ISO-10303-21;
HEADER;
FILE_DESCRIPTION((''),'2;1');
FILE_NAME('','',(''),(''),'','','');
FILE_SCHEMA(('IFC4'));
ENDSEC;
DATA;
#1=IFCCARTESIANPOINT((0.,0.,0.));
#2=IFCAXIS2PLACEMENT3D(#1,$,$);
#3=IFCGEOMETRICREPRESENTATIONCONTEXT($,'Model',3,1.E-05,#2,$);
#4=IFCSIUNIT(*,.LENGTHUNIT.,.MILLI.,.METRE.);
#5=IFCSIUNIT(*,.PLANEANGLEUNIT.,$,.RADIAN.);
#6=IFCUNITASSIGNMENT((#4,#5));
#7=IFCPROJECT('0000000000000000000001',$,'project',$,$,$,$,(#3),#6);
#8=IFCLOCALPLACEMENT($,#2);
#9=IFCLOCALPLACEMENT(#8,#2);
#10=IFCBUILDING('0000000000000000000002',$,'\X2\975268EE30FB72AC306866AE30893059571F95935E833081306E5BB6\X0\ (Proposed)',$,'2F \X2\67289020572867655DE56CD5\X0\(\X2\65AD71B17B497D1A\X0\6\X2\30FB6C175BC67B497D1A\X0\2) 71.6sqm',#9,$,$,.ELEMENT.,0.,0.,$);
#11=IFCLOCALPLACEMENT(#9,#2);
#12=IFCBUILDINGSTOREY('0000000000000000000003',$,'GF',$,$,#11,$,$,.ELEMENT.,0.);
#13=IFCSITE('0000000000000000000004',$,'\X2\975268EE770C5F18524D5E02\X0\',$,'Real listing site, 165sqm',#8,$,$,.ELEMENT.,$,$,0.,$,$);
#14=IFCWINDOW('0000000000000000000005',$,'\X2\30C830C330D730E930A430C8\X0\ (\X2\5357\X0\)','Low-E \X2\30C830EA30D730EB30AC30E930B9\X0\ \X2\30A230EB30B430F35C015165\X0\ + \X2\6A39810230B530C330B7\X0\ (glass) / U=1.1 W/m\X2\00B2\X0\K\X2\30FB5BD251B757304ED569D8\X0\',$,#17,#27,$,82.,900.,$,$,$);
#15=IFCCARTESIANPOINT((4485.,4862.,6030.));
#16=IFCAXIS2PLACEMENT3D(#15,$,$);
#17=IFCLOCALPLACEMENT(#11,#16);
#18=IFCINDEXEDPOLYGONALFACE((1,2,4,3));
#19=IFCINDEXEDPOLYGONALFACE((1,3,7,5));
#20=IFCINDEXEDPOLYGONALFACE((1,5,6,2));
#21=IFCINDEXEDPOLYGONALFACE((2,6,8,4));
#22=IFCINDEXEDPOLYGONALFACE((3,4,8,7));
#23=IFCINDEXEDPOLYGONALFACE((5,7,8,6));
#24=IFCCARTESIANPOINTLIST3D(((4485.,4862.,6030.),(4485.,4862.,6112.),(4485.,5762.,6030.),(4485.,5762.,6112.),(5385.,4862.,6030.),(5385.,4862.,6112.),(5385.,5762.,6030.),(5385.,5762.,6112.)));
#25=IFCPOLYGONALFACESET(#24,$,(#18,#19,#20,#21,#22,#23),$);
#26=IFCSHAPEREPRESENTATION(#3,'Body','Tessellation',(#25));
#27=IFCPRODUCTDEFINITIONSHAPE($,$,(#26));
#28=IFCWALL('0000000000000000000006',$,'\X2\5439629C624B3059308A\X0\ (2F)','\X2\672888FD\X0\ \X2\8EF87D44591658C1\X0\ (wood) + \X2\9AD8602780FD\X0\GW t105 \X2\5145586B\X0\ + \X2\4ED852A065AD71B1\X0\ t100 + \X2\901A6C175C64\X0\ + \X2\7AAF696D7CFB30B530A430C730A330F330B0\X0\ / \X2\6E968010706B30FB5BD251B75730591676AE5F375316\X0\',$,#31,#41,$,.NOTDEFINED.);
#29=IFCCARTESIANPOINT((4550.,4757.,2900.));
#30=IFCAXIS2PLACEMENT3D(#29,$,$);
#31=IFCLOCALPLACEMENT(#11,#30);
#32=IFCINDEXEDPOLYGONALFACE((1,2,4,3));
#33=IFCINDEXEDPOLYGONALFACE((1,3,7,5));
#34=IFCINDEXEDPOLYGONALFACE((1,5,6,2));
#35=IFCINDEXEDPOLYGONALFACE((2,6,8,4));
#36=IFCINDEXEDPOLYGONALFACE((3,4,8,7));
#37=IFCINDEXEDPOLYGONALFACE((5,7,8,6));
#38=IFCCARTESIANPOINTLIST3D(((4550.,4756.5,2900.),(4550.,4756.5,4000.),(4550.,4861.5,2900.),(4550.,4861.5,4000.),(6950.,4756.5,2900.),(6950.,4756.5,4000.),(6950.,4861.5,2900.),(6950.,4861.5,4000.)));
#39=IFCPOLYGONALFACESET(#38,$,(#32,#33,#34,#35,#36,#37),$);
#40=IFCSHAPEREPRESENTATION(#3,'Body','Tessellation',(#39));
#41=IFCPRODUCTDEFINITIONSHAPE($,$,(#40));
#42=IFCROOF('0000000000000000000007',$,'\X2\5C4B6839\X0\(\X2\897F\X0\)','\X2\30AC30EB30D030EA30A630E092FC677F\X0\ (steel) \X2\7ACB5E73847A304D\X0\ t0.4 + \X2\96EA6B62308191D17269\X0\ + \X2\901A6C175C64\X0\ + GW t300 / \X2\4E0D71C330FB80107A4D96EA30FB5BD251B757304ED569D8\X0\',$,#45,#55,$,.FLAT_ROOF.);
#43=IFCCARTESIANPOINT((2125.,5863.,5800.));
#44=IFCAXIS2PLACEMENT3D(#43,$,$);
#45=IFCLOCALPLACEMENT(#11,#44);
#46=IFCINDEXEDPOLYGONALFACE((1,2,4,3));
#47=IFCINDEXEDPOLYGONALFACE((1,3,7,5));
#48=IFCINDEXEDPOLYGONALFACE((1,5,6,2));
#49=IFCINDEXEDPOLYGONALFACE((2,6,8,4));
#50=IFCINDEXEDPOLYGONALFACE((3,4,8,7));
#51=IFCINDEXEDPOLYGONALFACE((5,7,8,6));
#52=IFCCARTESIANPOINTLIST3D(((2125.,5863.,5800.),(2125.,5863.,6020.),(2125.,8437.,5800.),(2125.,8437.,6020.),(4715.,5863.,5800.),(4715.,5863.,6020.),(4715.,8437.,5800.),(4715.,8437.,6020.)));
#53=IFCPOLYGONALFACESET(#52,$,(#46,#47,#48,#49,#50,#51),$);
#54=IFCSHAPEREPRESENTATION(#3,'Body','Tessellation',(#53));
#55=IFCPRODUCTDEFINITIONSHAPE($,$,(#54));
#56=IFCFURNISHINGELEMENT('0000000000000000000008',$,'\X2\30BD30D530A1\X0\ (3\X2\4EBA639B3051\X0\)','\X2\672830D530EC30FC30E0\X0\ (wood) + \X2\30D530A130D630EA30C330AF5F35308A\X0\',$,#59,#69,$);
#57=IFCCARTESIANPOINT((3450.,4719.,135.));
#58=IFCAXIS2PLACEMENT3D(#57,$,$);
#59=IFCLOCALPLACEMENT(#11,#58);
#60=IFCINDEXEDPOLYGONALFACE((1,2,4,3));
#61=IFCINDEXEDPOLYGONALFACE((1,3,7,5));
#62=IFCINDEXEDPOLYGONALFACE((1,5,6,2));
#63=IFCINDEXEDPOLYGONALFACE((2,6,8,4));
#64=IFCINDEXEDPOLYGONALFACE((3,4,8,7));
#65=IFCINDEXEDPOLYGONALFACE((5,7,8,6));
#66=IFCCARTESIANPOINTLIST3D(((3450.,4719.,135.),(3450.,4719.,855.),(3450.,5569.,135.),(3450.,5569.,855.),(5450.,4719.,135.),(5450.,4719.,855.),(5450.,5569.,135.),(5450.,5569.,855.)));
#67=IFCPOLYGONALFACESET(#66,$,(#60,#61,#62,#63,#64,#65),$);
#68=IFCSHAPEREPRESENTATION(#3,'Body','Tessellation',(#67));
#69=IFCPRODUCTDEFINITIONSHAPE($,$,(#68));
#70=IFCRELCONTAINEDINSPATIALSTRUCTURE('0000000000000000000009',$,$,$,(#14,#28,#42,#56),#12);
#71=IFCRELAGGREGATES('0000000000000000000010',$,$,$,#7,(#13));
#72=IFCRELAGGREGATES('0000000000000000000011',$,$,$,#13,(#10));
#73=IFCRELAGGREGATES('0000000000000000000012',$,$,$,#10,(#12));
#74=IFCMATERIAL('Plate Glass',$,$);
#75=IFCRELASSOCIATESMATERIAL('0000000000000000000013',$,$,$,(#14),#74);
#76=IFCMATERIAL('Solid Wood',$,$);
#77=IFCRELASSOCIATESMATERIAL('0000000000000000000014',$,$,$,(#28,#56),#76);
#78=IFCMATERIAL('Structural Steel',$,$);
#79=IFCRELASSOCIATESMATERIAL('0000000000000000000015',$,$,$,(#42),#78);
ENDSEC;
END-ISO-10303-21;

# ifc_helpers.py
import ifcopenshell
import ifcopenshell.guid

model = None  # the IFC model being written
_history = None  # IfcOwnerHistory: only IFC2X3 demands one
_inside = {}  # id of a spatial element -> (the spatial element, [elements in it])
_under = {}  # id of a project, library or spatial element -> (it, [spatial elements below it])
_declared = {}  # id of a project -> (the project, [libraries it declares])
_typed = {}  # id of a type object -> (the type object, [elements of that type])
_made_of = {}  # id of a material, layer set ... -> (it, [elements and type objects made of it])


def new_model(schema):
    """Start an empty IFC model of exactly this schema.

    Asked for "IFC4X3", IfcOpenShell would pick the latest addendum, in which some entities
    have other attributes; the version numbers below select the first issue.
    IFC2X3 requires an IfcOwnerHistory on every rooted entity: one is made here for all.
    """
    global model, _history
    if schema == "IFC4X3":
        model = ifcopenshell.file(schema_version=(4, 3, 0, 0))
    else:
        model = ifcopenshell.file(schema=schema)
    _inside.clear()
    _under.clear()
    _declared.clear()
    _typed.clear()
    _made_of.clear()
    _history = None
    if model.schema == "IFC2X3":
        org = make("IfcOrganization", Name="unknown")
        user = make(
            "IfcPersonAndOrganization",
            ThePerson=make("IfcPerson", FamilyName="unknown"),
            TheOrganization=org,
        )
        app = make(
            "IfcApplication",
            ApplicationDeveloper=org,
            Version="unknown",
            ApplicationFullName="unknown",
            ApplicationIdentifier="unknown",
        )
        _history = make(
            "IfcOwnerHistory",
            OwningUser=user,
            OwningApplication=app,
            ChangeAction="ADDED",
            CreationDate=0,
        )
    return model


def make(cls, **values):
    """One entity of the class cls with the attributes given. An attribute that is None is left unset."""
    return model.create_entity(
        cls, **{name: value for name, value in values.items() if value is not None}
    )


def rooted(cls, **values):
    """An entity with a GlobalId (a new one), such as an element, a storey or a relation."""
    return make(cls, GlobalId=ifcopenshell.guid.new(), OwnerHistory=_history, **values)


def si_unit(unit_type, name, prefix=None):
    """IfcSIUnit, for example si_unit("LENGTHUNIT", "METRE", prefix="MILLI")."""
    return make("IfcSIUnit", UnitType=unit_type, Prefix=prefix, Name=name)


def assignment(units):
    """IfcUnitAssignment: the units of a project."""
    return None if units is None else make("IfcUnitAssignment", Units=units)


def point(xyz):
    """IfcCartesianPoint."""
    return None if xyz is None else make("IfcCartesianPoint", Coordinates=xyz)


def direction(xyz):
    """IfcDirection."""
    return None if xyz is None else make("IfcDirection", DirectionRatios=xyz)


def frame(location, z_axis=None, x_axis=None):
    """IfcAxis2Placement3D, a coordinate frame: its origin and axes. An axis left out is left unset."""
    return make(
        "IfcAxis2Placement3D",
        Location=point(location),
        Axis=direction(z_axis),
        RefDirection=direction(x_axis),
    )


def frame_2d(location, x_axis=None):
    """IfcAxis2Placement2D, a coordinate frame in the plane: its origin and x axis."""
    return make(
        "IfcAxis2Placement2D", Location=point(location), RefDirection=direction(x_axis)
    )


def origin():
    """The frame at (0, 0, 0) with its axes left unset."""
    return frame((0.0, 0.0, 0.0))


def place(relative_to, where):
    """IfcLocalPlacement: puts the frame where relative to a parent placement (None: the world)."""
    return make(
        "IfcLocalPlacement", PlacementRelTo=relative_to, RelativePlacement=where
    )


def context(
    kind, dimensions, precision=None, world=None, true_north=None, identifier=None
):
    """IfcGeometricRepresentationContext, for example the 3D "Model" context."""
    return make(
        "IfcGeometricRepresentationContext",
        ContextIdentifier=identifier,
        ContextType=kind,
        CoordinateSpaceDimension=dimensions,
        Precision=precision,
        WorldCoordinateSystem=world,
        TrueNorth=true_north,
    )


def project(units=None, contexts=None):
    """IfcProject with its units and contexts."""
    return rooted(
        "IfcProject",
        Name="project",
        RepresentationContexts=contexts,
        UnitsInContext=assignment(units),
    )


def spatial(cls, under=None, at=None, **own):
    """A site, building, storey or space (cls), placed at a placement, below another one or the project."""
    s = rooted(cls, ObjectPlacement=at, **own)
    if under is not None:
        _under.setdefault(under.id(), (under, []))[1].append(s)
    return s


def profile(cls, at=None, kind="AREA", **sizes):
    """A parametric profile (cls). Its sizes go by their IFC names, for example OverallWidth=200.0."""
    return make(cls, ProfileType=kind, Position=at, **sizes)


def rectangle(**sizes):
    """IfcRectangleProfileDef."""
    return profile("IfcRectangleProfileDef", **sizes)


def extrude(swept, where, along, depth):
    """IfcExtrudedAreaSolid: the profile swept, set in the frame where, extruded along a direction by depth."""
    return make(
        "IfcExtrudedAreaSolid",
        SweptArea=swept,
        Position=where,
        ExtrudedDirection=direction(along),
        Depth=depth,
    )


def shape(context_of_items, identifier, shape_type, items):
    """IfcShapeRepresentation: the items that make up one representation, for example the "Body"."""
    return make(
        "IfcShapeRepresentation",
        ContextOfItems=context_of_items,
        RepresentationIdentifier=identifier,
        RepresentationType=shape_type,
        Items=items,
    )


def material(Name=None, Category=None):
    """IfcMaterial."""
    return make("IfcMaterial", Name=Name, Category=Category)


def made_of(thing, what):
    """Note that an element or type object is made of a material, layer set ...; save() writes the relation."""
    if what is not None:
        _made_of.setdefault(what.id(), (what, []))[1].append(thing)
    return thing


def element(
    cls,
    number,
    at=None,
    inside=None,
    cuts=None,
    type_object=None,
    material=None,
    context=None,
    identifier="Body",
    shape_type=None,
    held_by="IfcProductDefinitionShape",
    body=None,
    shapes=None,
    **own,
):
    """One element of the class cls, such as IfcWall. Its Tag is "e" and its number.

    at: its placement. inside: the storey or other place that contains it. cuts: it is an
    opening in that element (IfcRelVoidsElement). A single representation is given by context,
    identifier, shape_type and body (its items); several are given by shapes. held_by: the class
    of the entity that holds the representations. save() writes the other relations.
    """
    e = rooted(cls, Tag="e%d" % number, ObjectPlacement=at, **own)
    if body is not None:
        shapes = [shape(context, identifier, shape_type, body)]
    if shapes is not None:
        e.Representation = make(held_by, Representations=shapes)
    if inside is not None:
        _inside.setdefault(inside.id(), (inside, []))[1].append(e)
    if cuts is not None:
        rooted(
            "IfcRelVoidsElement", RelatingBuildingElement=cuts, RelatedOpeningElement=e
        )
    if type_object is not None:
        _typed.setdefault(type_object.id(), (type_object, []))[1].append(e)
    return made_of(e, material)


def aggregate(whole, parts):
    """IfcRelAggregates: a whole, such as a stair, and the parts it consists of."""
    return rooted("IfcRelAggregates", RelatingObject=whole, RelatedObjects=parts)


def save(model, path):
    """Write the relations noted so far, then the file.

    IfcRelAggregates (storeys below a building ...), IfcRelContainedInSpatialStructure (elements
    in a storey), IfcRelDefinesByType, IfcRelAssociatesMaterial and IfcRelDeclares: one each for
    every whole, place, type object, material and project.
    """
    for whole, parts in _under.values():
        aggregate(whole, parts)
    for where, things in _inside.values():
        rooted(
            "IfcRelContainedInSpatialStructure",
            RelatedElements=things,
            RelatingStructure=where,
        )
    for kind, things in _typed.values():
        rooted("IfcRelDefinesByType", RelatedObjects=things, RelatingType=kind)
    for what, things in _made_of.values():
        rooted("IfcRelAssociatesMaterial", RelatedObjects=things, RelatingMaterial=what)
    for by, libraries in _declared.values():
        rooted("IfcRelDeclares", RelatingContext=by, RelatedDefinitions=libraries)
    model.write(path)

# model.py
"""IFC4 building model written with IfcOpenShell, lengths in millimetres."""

from ifc_helpers import new_model, si_unit, frame, frame_2d, origin, place, context, project, spatial, rectangle, extrude, material, element, save


model = new_model("IFC4")

# Units and contexts
model_context = context("Model", 3, precision=1e-05, world=origin())
ifc_project = project(units=[si_unit("LENGTHUNIT", "METRE", prefix="MILLI"), si_unit("PLANEANGLEUNIT", "RADIAN")], contexts=[model_context])

# Site, building, storey
site_placement = place(None, origin())
site = spatial("IfcSite", under=ifc_project, at=site_placement, Name="青森県弘前市", ObjectType="Real listing site, 165sqm", CompositionType="ELEMENT", RefElevation=0.0)
building_placement = place(site_placement, origin())
building = spatial("IfcBuilding", under=site, at=building_placement, Name="青森・犬と暮らす土間広めの家 (Proposed)", ObjectType="2F 木造在来工法(断熱等級6・気密等級2) 71.6sqm", CompositionType="ELEMENT", ElevationOfRefHeight=0.0, ElevationOfTerrain=0.0)
storey_placement = place(building_placement, origin())
storey = spatial("IfcBuildingStorey", under=building, at=storey_placement, Name="GF", CompositionType="ELEMENT", Elevation=0.0)

# Shared definitions
ifc_material_1 = material(Name="Solid Wood")

# Shared definitions
ifc_material_2 = material(Name="Plate Glass")

# Window
window_1_placement = place(storey_placement, frame((4485.0, 4862.0, 6030.0)))
element("IfcWindow", 1, at=window_1_placement, inside=storey, material=ifc_material_2, Name="トップライト (南)", Description="Low-E トリプルガラス アルゴン封入 + 樹脂サッシ (glass) / U=1.1 W/m²K・寒冷地仕様", OverallHeight=82.0, OverallWidth=900.0, context=model_context, shape_type="SweptSolid", body=[
    extrude(rectangle(XDim=900.0, YDim=900.0, at=frame_2d((450.0, 450.0))), frame((4485.0, 4862.0, 6030.0)), (0.0, 0.0, 1.0), 82.0),
])

# Wall
wall_1_placement = place(storey_placement, frame((4550.0, 4757.0, 2900.0)))
element("IfcWall", 2, at=wall_1_placement, inside=storey, material=ifc_material_1, Name="吹抜手すり (2F)", Description="木製 軸組外壁 (wood) + 高性能GW t105 充填 + 付加断熱 t100 + 通気層 + 窯業系サイディング / 準耐火・寒冷地外皮強化", PredefinedType="NOTDEFINED", context=model_context, shape_type="SweptSolid", body=[
    extrude(rectangle(XDim=2400.0, YDim=105.0, at=frame_2d((1200.0, 52.0))), frame((4550.0, 4757.0, 2900.0)), (0.0, 0.0, 1.0), 1100.0),
])

# Roof
ifc_material_3 = material(Name="Structural Steel")
for number, where, name in (
    (3, (2125.0, 5863.0, 5800.0), "屋根(西)"),
):
    element("IfcRoof", number, at=place(storey_placement, frame(where)), inside=storey, material=ifc_material_3, Name=name, Description="ガルバリウム鋼板 (steel) 立平葺き t0.4 + 雪止め金物 + 通気層 + GW t300 / 不燃・耐積雪・寒冷地仕様", PredefinedType="FLAT_ROOF", context=model_context, shape_type="SweptSolid", body=[
        extrude(rectangle(XDim=2590.0, YDim=2574.0, at=frame_2d((1295.0, 1287.0))), frame((2125.0, 5863.0, 5800.0)), (0.0, 0.0, 1.0), 220.0),
    ])

# Furnishing element
furnishing_placement = place(storey_placement, frame((3450.0, 4719.0, 135.0)))
element("IfcFurnishingElement", 4, at=furnishing_placement, inside=storey, material=ifc_material_1, Name="ソファ (3人掛け)", Description="木フレーム (wood) + ファブリック張り", context=model_context, shape_type="SweptSolid", body=[
    extrude(rectangle(XDim=2000.0, YDim=850.0, at=frame_2d((1000.0, 425.0))), frame((3450.0, 4719.0, 135.0)), (0.0, 0.0, 1.0), 720.0),
])

save(model, "model.ifc")
